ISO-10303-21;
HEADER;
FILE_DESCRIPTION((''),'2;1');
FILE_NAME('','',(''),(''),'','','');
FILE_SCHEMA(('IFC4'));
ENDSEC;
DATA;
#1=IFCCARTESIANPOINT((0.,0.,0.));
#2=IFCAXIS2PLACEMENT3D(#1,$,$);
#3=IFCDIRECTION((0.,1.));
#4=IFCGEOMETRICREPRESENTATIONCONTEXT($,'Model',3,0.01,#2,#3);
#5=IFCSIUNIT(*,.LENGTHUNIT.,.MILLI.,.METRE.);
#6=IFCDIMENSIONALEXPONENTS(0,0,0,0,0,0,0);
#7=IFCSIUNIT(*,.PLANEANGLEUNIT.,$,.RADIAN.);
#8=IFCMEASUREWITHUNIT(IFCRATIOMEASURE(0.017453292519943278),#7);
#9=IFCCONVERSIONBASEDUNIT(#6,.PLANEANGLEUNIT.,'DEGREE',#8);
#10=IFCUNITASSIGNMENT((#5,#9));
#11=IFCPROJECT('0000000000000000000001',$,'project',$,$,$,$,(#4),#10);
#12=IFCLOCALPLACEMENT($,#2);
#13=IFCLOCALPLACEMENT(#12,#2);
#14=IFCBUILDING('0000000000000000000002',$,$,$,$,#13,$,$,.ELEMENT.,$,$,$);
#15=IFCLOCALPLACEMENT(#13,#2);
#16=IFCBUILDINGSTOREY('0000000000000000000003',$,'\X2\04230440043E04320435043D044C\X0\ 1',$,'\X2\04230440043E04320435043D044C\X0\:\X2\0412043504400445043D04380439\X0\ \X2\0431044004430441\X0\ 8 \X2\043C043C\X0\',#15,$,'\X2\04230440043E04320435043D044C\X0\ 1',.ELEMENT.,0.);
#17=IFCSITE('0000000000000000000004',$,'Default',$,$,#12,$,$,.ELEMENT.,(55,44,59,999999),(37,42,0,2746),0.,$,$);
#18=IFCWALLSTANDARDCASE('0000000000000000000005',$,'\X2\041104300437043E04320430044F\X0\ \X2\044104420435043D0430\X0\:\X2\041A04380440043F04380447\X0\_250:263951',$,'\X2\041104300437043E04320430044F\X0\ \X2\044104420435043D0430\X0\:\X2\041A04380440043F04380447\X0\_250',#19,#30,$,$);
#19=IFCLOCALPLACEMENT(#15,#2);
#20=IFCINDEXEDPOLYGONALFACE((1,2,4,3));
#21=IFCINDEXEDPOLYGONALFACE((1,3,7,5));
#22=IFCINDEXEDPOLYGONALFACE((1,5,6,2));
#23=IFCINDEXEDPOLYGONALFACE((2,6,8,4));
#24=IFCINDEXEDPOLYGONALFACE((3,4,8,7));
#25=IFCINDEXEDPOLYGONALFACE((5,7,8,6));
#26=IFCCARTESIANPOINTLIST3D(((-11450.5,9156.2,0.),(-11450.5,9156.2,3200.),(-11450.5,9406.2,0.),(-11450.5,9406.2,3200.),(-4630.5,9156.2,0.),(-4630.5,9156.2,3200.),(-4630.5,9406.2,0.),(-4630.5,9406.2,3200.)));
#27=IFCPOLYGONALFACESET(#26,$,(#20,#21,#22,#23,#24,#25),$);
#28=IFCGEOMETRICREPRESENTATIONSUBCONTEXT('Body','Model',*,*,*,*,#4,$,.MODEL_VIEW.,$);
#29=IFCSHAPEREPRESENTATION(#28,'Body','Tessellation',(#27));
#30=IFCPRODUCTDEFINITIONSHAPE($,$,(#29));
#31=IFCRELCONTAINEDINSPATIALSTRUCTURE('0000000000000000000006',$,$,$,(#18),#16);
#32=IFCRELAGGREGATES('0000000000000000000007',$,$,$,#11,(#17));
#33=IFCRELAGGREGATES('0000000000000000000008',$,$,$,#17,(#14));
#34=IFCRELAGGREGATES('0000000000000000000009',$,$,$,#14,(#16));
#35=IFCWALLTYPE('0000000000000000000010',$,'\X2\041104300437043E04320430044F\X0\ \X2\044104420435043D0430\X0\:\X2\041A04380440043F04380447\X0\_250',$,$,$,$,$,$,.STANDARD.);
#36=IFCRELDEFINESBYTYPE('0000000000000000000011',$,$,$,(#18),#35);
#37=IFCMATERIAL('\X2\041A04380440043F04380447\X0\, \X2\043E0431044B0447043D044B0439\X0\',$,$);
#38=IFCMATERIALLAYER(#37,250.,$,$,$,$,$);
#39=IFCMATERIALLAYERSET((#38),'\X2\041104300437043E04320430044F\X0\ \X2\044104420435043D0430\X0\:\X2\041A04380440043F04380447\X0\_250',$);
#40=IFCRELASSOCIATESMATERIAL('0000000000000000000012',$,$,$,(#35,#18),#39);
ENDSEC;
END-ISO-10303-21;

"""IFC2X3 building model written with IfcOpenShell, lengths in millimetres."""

from ifc_helpers import new_model, entity, si_unit, converted_unit, direction, frame, frame_2d, origin, place, context, subcontext, project, spatial, rectangle, extrude, material, layer, layer_set, layer_usage, type_object, element, save


model = new_model("IFC2X3")

# Units and contexts
model_context = context("Model", 3, precision=0.01, world=origin(), true_north=direction((0.0, 1.0)))
body_context = subcontext(model_context, "Body", "Model", "MODEL_VIEW")
ifc_project = project(units=[si_unit("LENGTHUNIT", "METRE", prefix="MILLI"), converted_unit("PLANEANGLEUNIT", "DEGREE", entity("IfcRatioMeasure", 0.017453292519943278), si_unit("PLANEANGLEUNIT", "RADIAN"), dimensions=[0, 0, 0, 0, 0, 0, 0])], contexts=[model_context])

# Site, building, storey
site_placement = place(None, origin())
site = spatial("IfcSite", under=ifc_project, at=site_placement, Name="Default", CompositionType="ELEMENT", RefLatitude=(55, 44, 59, 999999), RefLongitude=(37, 42, 0, 2746), RefElevation=0.0)
building_placement = place(site_placement, origin())
building = spatial("IfcBuilding", under=site, at=building_placement, CompositionType="ELEMENT")
storey_placement = place(building_placement, origin())
storey = spatial("IfcBuildingStorey", under=building, at=storey_placement, Name="Уровень 1", ObjectType="Уровень:Верхний брус 8 мм", LongName="Уровень 1", CompositionType="ELEMENT", Elevation=0.0)

# Wall
ifc_material_1 = material(Name="Кирпич, обычный")
ifc_layer_1 = layer(ifc_material_1, 250.0)
ifc_layer_set_1 = layer_set([ifc_layer_1], Name="Базовая стена:Кирпич_250")
ifc_layer_usage_1 = layer_usage(ifc_layer_set_1, "AXIS2", "NEGATIVE", 125.0)
wall_type_1 = type_object("IfcWallType", Name="Базовая стена:Кирпич_250", PredefinedType="STANDARD", material=ifc_layer_set_1)
wall_1_placement = place(storey_placement, frame((-4630.5, 9281.2, 0.0), z_axis=(0.0, 0.0, 1.0), x_axis=(-1.0, 0.0, 0.0)))
element("IfcWallStandardCase", 1, at=wall_1_placement, inside=storey, type_object=wall_type_1, material=ifc_layer_usage_1, Name="Базовая стена:Кирпич_250:263951", ObjectType="Базовая стена:Кирпич_250", context=body_context, shape_type="SweptSolid", body=[
    extrude(rectangle(XDim=6820.0, YDim=250.0, at=frame_2d((3410.0, 0.0), x_axis=(-1.0, 0.0))), origin(), (0.0, 0.0, 1.0), 3200.0),
])

save(model, "model.ifc")
